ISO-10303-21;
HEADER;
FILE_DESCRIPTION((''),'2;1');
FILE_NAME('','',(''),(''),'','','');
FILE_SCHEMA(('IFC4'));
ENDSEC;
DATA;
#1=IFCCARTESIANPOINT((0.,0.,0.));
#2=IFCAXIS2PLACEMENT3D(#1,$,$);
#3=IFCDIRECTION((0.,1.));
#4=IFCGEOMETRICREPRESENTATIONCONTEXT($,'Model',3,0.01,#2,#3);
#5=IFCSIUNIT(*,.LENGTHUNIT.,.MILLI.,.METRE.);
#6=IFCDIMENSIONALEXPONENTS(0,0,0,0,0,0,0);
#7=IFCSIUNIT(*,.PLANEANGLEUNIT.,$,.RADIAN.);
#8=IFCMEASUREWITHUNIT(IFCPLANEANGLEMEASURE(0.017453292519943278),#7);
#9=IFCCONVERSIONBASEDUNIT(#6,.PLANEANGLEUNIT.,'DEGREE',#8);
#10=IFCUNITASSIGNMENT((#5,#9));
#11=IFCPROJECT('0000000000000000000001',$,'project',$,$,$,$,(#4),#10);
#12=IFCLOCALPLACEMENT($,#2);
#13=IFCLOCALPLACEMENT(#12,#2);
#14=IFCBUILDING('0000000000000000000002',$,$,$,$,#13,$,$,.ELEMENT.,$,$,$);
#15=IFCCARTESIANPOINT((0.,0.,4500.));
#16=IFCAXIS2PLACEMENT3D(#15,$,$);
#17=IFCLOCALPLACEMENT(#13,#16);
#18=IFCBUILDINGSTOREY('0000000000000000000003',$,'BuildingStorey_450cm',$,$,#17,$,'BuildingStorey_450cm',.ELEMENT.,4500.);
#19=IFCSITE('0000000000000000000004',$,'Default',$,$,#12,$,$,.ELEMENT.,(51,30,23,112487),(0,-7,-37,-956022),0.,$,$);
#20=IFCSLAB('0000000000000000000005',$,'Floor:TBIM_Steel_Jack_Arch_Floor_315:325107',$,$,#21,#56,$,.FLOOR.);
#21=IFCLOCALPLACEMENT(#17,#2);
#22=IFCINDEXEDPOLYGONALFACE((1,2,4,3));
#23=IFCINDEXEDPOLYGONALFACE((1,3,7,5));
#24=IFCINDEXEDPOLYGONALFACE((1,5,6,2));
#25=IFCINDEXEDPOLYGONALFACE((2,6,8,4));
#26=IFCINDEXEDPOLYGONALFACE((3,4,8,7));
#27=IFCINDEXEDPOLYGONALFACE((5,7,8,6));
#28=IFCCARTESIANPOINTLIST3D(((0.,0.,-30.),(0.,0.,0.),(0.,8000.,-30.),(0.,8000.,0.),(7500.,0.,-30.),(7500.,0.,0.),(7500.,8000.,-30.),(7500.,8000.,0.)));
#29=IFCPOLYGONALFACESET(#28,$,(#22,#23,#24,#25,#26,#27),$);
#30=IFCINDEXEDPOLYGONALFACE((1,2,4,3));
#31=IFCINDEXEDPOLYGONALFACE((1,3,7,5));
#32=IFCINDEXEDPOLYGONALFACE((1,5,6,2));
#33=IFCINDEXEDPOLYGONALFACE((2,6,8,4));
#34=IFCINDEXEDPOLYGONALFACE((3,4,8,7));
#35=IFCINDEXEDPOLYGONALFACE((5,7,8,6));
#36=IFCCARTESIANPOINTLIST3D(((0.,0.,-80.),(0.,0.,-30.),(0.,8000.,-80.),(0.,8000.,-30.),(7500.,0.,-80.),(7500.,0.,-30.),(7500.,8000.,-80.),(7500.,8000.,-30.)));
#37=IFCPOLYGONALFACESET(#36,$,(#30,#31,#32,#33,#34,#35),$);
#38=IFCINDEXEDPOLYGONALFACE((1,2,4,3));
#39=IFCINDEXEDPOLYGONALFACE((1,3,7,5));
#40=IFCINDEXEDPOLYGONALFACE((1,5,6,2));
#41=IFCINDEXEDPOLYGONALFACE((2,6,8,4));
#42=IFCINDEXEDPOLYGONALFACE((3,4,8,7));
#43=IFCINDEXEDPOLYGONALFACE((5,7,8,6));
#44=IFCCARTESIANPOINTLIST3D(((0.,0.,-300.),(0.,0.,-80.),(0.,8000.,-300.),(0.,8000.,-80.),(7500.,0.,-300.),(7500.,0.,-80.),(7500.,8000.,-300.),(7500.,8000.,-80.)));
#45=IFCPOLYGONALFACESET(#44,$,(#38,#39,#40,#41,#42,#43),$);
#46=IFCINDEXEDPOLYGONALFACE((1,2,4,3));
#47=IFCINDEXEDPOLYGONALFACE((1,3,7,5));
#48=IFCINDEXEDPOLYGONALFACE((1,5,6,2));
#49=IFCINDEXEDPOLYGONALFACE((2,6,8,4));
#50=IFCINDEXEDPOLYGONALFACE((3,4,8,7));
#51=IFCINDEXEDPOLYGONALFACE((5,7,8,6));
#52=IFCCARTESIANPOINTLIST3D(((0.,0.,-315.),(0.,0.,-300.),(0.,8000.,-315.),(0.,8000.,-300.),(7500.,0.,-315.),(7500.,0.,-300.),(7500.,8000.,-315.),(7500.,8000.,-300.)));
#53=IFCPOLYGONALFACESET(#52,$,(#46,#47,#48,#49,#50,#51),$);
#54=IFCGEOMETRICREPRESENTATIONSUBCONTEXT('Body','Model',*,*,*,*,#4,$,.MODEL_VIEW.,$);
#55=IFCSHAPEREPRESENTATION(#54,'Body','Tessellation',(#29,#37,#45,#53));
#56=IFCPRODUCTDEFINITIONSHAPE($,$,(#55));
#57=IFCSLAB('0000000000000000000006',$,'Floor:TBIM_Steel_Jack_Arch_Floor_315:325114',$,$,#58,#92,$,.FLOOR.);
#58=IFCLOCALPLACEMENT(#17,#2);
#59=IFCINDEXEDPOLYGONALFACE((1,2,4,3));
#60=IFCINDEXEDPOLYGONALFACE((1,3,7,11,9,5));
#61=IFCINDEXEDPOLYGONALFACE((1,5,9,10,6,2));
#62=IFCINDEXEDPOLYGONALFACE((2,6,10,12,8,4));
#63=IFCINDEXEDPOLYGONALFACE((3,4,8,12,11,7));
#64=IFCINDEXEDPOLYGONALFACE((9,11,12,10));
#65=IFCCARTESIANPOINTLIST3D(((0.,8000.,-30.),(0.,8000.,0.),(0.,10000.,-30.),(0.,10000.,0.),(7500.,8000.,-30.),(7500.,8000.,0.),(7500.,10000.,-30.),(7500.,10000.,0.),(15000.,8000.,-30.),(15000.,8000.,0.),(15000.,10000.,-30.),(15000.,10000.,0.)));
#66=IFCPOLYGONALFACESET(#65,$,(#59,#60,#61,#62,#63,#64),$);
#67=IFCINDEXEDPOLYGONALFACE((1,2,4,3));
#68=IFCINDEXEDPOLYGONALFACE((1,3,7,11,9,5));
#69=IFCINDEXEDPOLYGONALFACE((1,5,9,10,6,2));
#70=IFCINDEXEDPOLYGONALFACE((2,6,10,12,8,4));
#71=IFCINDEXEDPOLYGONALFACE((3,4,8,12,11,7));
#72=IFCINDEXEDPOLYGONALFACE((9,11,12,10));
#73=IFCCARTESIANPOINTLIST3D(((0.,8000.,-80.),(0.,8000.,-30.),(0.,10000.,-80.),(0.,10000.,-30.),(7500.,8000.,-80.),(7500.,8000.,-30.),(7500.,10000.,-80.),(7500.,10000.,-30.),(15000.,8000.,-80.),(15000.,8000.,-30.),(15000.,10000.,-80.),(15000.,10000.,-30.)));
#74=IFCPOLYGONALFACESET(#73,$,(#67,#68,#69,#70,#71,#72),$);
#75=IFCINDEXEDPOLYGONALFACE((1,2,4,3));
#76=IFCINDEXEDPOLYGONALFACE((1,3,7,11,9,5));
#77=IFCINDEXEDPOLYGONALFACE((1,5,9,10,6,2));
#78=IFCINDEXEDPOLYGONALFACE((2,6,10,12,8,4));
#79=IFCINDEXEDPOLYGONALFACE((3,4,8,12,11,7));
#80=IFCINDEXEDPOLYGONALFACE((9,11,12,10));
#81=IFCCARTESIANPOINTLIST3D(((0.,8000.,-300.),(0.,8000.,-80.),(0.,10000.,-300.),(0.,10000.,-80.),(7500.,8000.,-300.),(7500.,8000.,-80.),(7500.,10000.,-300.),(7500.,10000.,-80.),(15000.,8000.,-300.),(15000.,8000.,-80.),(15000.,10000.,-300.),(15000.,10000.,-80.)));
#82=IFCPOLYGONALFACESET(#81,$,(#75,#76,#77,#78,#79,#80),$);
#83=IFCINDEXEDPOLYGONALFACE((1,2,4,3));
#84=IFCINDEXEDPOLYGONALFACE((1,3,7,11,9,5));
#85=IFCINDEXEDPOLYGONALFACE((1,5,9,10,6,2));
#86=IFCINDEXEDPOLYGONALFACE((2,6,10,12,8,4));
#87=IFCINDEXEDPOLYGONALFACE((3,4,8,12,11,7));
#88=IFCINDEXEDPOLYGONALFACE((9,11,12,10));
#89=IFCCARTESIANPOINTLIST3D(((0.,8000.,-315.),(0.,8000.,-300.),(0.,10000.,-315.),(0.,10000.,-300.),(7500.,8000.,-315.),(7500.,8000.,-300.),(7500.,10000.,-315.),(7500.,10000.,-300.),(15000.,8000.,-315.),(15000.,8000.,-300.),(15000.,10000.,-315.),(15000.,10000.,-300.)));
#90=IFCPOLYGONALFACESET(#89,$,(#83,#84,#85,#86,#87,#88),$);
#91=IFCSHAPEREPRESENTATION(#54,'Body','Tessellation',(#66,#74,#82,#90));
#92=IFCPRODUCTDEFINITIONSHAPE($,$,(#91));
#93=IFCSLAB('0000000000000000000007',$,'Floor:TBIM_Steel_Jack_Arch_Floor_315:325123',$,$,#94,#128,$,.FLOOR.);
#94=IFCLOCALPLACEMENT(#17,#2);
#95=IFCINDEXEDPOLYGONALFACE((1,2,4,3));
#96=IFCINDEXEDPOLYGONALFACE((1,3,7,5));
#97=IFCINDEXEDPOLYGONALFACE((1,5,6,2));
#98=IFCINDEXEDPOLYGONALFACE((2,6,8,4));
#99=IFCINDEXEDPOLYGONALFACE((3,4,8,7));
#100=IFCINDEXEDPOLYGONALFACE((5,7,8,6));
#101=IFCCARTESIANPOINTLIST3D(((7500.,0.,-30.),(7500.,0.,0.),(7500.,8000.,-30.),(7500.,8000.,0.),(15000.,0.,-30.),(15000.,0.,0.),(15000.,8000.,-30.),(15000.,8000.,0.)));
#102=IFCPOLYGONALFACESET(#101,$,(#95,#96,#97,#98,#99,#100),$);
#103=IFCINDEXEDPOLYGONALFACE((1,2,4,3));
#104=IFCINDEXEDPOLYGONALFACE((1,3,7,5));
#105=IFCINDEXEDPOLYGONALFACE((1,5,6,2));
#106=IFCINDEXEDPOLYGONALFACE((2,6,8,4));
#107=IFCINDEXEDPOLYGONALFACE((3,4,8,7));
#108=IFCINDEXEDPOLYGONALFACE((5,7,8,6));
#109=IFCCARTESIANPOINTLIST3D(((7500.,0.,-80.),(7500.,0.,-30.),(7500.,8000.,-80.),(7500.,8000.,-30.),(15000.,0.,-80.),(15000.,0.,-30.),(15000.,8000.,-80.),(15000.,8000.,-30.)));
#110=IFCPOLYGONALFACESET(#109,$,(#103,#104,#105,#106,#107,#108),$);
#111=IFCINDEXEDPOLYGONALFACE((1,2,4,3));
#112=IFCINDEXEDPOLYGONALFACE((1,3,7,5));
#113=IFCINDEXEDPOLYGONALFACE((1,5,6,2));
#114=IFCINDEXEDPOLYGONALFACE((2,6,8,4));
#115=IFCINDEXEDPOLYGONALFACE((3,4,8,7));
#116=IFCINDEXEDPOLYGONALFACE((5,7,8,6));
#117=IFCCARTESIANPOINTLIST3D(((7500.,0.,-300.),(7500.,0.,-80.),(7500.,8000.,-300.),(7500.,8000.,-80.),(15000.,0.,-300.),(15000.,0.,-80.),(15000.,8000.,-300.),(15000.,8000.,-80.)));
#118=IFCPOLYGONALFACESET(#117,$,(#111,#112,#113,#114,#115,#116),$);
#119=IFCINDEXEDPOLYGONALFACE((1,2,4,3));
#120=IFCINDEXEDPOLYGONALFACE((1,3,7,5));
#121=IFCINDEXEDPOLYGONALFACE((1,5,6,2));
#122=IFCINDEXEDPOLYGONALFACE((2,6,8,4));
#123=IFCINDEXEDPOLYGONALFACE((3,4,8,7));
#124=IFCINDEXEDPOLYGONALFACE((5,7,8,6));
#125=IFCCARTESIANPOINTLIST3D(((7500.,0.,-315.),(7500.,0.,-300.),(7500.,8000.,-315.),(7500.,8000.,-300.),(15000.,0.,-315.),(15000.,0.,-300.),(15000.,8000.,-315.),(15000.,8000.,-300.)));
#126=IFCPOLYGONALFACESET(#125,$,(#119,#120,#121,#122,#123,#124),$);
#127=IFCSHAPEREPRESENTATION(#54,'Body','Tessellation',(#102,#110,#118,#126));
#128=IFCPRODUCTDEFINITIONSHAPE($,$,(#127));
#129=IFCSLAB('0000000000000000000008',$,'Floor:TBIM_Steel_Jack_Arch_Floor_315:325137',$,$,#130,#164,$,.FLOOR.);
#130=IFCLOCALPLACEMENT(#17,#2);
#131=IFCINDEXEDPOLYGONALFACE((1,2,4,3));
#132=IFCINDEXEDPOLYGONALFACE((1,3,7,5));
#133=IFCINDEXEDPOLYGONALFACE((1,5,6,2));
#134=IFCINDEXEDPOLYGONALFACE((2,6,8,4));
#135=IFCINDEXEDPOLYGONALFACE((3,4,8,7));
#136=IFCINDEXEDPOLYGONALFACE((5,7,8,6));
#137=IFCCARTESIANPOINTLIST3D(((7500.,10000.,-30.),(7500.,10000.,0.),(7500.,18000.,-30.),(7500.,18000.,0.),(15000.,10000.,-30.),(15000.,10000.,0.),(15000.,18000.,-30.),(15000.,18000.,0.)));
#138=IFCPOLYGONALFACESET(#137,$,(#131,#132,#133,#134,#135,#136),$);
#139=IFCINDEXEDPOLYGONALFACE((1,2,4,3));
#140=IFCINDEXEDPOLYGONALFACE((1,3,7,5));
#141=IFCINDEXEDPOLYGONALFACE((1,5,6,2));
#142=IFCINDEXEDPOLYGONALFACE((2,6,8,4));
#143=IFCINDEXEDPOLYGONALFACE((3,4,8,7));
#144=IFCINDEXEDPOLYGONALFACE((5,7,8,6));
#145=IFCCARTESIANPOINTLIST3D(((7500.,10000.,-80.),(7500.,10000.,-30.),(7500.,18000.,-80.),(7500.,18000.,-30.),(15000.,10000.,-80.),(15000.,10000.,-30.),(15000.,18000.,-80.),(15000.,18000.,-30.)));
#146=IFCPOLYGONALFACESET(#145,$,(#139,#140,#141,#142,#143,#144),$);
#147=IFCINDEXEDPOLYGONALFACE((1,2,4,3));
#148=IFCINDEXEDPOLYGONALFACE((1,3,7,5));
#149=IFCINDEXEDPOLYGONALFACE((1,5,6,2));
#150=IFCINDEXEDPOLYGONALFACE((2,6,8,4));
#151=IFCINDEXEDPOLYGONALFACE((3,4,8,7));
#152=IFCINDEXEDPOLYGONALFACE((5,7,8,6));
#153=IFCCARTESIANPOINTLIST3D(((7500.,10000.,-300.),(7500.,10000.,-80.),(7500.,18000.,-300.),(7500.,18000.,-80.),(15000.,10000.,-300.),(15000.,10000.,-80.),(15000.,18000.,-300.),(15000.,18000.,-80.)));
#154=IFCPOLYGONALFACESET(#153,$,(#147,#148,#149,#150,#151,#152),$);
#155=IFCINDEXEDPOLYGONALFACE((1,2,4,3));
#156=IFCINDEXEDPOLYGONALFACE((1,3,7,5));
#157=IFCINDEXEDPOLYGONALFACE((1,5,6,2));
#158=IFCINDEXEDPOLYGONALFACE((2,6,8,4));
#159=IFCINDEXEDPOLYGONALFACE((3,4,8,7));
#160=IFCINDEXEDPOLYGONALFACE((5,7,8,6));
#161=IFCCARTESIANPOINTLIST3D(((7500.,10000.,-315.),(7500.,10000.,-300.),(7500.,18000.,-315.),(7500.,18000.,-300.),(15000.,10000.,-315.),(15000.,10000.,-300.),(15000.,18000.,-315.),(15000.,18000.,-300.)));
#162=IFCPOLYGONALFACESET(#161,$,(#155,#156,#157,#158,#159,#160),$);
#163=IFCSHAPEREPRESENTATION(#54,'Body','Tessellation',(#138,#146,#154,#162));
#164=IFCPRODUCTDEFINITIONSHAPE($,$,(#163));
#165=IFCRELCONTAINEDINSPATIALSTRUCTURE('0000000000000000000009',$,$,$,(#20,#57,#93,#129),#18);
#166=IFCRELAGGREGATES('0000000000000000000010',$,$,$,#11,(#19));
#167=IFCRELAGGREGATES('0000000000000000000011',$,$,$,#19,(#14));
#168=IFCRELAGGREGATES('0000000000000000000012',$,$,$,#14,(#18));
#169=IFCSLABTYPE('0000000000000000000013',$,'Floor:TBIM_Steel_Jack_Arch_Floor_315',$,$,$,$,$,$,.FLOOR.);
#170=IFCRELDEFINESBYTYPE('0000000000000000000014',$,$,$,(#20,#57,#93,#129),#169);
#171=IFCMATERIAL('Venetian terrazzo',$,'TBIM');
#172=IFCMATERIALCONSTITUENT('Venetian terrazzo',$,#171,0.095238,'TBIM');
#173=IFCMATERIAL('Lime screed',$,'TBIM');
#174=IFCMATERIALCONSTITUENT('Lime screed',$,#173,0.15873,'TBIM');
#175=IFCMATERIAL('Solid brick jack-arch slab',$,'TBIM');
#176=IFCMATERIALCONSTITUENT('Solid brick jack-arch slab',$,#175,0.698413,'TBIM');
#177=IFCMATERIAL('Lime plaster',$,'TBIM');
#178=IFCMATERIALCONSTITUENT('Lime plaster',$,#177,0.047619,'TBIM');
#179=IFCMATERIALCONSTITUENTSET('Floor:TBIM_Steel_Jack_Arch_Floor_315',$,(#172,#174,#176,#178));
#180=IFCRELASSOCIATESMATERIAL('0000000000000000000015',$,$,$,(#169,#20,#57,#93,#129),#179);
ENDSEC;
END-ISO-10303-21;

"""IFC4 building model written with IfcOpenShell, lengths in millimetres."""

from ifc_helpers import new_model, entity, si_unit, converted_unit, direction, frame, origin, place, context, subcontext, project, spatial, indexed_curve, outline, extrude, material, constituent, constituent_set, type_object, element, save


model = new_model("IFC4")

# Units and contexts
model_context = context("Model", 3, precision=0.01, world=origin(), true_north=direction((0.0, 1.0)))
body_context = subcontext(model_context, "Body", "Model", "MODEL_VIEW")
ifc_project = project(units=[si_unit("LENGTHUNIT", "METRE", prefix="MILLI"), converted_unit("PLANEANGLEUNIT", "DEGREE", entity("IfcPlaneAngleMeasure", 0.017453292519943278), si_unit("PLANEANGLEUNIT", "RADIAN"), dimensions=[0, 0, 0, 0, 0, 0, 0])], contexts=[model_context])

# Site, building, storey
site_placement = place(None, origin())
site = spatial("IfcSite", under=ifc_project, at=site_placement, Name="Default", CompositionType="ELEMENT", RefLatitude=(51, 30, 23, 112487), RefLongitude=(0, -7, -37, -956022), RefElevation=0.0)
building_placement = place(site_placement, origin())
building = spatial("IfcBuilding", under=site, at=building_placement, CompositionType="ELEMENT")
storey_placement = place(building_placement, frame((0.0, 0.0, 4500.0)))
storey = spatial("IfcBuildingStorey", under=building, at=storey_placement, Name="BuildingStorey_450cm", LongName="BuildingStorey_450cm", CompositionType="ELEMENT", Elevation=4500.0)

# Slabs
ifc_material_1 = material(Name="Venetian terrazzo", Category="TBIM")
ifc_constituent_1 = constituent(ifc_material_1, Name="Venetian terrazzo", Category="TBIM", fraction=0.095238)
ifc_material_2 = material(Name="Lime screed", Category="TBIM")
ifc_constituent_2 = constituent(ifc_material_2, Name="Lime screed", Category="TBIM", fraction=0.15873)
ifc_material_3 = material(Name="Solid brick jack-arch slab", Category="TBIM")
ifc_constituent_3 = constituent(ifc_material_3, Name="Solid brick jack-arch slab", Category="TBIM", fraction=0.698413)
ifc_material_4 = material(Name="Lime plaster", Category="TBIM")
ifc_constituent_4 = constituent(ifc_material_4, Name="Lime plaster", Category="TBIM", fraction=0.047619)
ifc_constituent_set_1 = constituent_set(constituents=[ifc_constituent_1, ifc_constituent_2, ifc_constituent_3, ifc_constituent_4], Name="Floor:TBIM_Steel_Jack_Arch_Floor_315")
slab_type = type_object("IfcSlabType", Name="Floor:TBIM_Steel_Jack_Arch_Floor_315", PredefinedType="FLOOR", material=ifc_constituent_set_1)
slab_1_placement = place(storey_placement, origin())
element("IfcSlab", 1, at=slab_1_placement, inside=storey, type_object=slab_type, material=ifc_constituent_set_1, Name="Floor:TBIM_Steel_Jack_Arch_Floor_315:325107", PredefinedType="FLOOR", context=body_context, shape_type="SweptSolid", body=[
    extrude(outline(indexed_curve([(-3750.0, -4000.0), (3750.0, -4000.0), (3750.0, 4000.0), (-3750.0, 4000.0), (-3750.0, -4000.0)], self_intersect=False)), frame((3750.0, 4000.0, -30.0), z_axis=(0.0, 0.0, 1.0), x_axis=(-1.0, 0.0, 0.0)), (0.0, 0.0, 1.0), 30.0),
    extrude(outline(indexed_curve([(-3750.0, -4000.0), (3750.0, -4000.0), (3750.0, 4000.0), (-3750.0, 4000.0), (-3750.0, -4000.0)], self_intersect=False)), frame((3750.0, 4000.0, -80.0), z_axis=(0.0, 0.0, 1.0), x_axis=(-1.0, 0.0, 0.0)), (0.0, 0.0, 1.0), 50.0),
    extrude(outline(indexed_curve([(-3750.0, -4000.0), (3750.0, -4000.0), (3750.0, 4000.0), (-3750.0, 4000.0), (-3750.0, -4000.0)], self_intersect=False)), frame((3750.0, 4000.0, -300.0), z_axis=(0.0, 0.0, 1.0), x_axis=(-1.0, 0.0, 0.0)), (0.0, 0.0, 1.0), 220.0),
    extrude(outline(indexed_curve([(-3750.0, -4000.0), (3750.0, -4000.0), (3750.0, 4000.0), (-3750.0, 4000.0), (-3750.0, -4000.0)], self_intersect=False)), frame((3750.0, 4000.0, -315.0), z_axis=(0.0, 0.0, 1.0), x_axis=(-1.0, 0.0, 0.0)), (0.0, 0.0, 1.0), 15.0),
])
slab_2_placement = place(storey_placement, origin())
element("IfcSlab", 2, at=slab_2_placement, inside=storey, type_object=slab_type, material=ifc_constituent_set_1, Name="Floor:TBIM_Steel_Jack_Arch_Floor_315:325114", PredefinedType="FLOOR", context=body_context, shape_type="SweptSolid", body=[
    extrude(outline(indexed_curve([(-7500.0, -1000.0), (0.0, -1000.0), (7500.0, -1000.0), (7500.0, 1000.0), (0.0, 1000.0), (-7500.0, 1000.0), (-7500.0, -1000.0)], self_intersect=False)), frame((7500.0, 9000.0, -30.0), z_axis=(0.0, 0.0, 1.0), x_axis=(-1.0, 0.0, 0.0)), (0.0, 0.0, 1.0), 30.0),
    extrude(outline(indexed_curve([(-7500.0, -1000.0), (0.0, -1000.0), (7500.0, -1000.0), (7500.0, 1000.0), (0.0, 1000.0), (-7500.0, 1000.0), (-7500.0, -1000.0)], self_intersect=False)), frame((7500.0, 9000.0, -80.0), z_axis=(0.0, 0.0, 1.0), x_axis=(-1.0, 0.0, 0.0)), (0.0, 0.0, 1.0), 50.0),
    extrude(outline(indexed_curve([(-7500.0, -1000.0), (0.0, -1000.0), (7500.0, -1000.0), (7500.0, 1000.0), (0.0, 1000.0), (-7500.0, 1000.0), (-7500.0, -1000.0)], self_intersect=False)), frame((7500.0, 9000.0, -300.0), z_axis=(0.0, 0.0, 1.0), x_axis=(-1.0, 0.0, 0.0)), (0.0, 0.0, 1.0), 220.0),
    extrude(outline(indexed_curve([(-7500.0, -1000.0), (0.0, -1000.0), (7500.0, -1000.0), (7500.0, 1000.0), (0.0, 1000.0), (-7500.0, 1000.0), (-7500.0, -1000.0)], self_intersect=False)), frame((7500.0, 9000.0, -315.0), z_axis=(0.0, 0.0, 1.0), x_axis=(-1.0, 0.0, 0.0)), (0.0, 0.0, 1.0), 15.0),
])
slab_3_placement = place(storey_placement, origin())
element("IfcSlab", 3, at=slab_3_placement, inside=storey, type_object=slab_type, material=ifc_constituent_set_1, Name="Floor:TBIM_Steel_Jack_Arch_Floor_315:325123", PredefinedType="FLOOR", context=body_context, shape_type="SweptSolid", body=[
    extrude(outline(indexed_curve([(-3750.0, -4000.0), (3750.0, -4000.0), (3750.0, 4000.0), (-3750.0, 4000.0), (-3750.0, -4000.0)], self_intersect=False)), frame((11250.0, 4000.0, -30.0), z_axis=(0.0, 0.0, 1.0), x_axis=(-1.0, 0.0, 0.0)), (0.0, 0.0, 1.0), 30.0),
    extrude(outline(indexed_curve([(-3750.0, -4000.0), (3750.0, -4000.0), (3750.0, 4000.0), (-3750.0, 4000.0), (-3750.0, -4000.0)], self_intersect=False)), frame((11250.0, 4000.0, -80.0), z_axis=(0.0, 0.0, 1.0), x_axis=(-1.0, 0.0, 0.0)), (0.0, 0.0, 1.0), 50.0),
    extrude(outline(indexed_curve([(-3750.0, -4000.0), (3750.0, -4000.0), (3750.0, 4000.0), (-3750.0, 4000.0), (-3750.0, -4000.0)], self_intersect=False)), frame((11250.0, 4000.0, -300.0), z_axis=(0.0, 0.0, 1.0), x_axis=(-1.0, 0.0, 0.0)), (0.0, 0.0, 1.0), 220.0),
    extrude(outline(indexed_curve([(-3750.0, -4000.0), (3750.0, -4000.0), (3750.0, 4000.0), (-3750.0, 4000.0), (-3750.0, -4000.0)], self_intersect=False)), frame((11250.0, 4000.0, -315.0), z_axis=(0.0, 0.0, 1.0), x_axis=(-1.0, 0.0, 0.0)), (0.0, 0.0, 1.0), 15.0),
])
slab_4_placement = place(storey_placement, origin())
element("IfcSlab", 4, at=slab_4_placement, inside=storey, type_object=slab_type, material=ifc_constituent_set_1, Name="Floor:TBIM_Steel_Jack_Arch_Floor_315:325137", PredefinedType="FLOOR", context=body_context, shape_type="SweptSolid", body=[
    extrude(outline(indexed_curve([(-3750.0, -4000.0), (3750.0, -4000.0), (3750.0, 4000.0), (-3750.0, 4000.0), (-3750.0, -4000.0)], self_intersect=False)), frame((11250.0, 14000.0, -30.0), z_axis=(0.0, 0.0, 1.0), x_axis=(-1.0, 0.0, 0.0)), (0.0, 0.0, 1.0), 30.0),
    extrude(outline(indexed_curve([(-3750.0, -4000.0), (3750.0, -4000.0), (3750.0, 4000.0), (-3750.0, 4000.0), (-3750.0, -4000.0)], self_intersect=False)), frame((11250.0, 14000.0, -80.0), z_axis=(0.0, 0.0, 1.0), x_axis=(-1.0, 0.0, 0.0)), (0.0, 0.0, 1.0), 50.0),
    extrude(outline(indexed_curve([(-3750.0, -4000.0), (3750.0, -4000.0), (3750.0, 4000.0), (-3750.0, 4000.0), (-3750.0, -4000.0)], self_intersect=False)), frame((11250.0, 14000.0, -300.0), z_axis=(0.0, 0.0, 1.0), x_axis=(-1.0, 0.0, 0.0)), (0.0, 0.0, 1.0), 220.0),
    extrude(outline(indexed_curve([(-3750.0, -4000.0), (3750.0, -4000.0), (3750.0, 4000.0), (-3750.0, 4000.0), (-3750.0, -4000.0)], self_intersect=False)), frame((11250.0, 14000.0, -315.0), z_axis=(0.0, 0.0, 1.0), x_axis=(-1.0, 0.0, 0.0)), (0.0, 0.0, 1.0), 15.0),
])

save(model, "model.ifc")
